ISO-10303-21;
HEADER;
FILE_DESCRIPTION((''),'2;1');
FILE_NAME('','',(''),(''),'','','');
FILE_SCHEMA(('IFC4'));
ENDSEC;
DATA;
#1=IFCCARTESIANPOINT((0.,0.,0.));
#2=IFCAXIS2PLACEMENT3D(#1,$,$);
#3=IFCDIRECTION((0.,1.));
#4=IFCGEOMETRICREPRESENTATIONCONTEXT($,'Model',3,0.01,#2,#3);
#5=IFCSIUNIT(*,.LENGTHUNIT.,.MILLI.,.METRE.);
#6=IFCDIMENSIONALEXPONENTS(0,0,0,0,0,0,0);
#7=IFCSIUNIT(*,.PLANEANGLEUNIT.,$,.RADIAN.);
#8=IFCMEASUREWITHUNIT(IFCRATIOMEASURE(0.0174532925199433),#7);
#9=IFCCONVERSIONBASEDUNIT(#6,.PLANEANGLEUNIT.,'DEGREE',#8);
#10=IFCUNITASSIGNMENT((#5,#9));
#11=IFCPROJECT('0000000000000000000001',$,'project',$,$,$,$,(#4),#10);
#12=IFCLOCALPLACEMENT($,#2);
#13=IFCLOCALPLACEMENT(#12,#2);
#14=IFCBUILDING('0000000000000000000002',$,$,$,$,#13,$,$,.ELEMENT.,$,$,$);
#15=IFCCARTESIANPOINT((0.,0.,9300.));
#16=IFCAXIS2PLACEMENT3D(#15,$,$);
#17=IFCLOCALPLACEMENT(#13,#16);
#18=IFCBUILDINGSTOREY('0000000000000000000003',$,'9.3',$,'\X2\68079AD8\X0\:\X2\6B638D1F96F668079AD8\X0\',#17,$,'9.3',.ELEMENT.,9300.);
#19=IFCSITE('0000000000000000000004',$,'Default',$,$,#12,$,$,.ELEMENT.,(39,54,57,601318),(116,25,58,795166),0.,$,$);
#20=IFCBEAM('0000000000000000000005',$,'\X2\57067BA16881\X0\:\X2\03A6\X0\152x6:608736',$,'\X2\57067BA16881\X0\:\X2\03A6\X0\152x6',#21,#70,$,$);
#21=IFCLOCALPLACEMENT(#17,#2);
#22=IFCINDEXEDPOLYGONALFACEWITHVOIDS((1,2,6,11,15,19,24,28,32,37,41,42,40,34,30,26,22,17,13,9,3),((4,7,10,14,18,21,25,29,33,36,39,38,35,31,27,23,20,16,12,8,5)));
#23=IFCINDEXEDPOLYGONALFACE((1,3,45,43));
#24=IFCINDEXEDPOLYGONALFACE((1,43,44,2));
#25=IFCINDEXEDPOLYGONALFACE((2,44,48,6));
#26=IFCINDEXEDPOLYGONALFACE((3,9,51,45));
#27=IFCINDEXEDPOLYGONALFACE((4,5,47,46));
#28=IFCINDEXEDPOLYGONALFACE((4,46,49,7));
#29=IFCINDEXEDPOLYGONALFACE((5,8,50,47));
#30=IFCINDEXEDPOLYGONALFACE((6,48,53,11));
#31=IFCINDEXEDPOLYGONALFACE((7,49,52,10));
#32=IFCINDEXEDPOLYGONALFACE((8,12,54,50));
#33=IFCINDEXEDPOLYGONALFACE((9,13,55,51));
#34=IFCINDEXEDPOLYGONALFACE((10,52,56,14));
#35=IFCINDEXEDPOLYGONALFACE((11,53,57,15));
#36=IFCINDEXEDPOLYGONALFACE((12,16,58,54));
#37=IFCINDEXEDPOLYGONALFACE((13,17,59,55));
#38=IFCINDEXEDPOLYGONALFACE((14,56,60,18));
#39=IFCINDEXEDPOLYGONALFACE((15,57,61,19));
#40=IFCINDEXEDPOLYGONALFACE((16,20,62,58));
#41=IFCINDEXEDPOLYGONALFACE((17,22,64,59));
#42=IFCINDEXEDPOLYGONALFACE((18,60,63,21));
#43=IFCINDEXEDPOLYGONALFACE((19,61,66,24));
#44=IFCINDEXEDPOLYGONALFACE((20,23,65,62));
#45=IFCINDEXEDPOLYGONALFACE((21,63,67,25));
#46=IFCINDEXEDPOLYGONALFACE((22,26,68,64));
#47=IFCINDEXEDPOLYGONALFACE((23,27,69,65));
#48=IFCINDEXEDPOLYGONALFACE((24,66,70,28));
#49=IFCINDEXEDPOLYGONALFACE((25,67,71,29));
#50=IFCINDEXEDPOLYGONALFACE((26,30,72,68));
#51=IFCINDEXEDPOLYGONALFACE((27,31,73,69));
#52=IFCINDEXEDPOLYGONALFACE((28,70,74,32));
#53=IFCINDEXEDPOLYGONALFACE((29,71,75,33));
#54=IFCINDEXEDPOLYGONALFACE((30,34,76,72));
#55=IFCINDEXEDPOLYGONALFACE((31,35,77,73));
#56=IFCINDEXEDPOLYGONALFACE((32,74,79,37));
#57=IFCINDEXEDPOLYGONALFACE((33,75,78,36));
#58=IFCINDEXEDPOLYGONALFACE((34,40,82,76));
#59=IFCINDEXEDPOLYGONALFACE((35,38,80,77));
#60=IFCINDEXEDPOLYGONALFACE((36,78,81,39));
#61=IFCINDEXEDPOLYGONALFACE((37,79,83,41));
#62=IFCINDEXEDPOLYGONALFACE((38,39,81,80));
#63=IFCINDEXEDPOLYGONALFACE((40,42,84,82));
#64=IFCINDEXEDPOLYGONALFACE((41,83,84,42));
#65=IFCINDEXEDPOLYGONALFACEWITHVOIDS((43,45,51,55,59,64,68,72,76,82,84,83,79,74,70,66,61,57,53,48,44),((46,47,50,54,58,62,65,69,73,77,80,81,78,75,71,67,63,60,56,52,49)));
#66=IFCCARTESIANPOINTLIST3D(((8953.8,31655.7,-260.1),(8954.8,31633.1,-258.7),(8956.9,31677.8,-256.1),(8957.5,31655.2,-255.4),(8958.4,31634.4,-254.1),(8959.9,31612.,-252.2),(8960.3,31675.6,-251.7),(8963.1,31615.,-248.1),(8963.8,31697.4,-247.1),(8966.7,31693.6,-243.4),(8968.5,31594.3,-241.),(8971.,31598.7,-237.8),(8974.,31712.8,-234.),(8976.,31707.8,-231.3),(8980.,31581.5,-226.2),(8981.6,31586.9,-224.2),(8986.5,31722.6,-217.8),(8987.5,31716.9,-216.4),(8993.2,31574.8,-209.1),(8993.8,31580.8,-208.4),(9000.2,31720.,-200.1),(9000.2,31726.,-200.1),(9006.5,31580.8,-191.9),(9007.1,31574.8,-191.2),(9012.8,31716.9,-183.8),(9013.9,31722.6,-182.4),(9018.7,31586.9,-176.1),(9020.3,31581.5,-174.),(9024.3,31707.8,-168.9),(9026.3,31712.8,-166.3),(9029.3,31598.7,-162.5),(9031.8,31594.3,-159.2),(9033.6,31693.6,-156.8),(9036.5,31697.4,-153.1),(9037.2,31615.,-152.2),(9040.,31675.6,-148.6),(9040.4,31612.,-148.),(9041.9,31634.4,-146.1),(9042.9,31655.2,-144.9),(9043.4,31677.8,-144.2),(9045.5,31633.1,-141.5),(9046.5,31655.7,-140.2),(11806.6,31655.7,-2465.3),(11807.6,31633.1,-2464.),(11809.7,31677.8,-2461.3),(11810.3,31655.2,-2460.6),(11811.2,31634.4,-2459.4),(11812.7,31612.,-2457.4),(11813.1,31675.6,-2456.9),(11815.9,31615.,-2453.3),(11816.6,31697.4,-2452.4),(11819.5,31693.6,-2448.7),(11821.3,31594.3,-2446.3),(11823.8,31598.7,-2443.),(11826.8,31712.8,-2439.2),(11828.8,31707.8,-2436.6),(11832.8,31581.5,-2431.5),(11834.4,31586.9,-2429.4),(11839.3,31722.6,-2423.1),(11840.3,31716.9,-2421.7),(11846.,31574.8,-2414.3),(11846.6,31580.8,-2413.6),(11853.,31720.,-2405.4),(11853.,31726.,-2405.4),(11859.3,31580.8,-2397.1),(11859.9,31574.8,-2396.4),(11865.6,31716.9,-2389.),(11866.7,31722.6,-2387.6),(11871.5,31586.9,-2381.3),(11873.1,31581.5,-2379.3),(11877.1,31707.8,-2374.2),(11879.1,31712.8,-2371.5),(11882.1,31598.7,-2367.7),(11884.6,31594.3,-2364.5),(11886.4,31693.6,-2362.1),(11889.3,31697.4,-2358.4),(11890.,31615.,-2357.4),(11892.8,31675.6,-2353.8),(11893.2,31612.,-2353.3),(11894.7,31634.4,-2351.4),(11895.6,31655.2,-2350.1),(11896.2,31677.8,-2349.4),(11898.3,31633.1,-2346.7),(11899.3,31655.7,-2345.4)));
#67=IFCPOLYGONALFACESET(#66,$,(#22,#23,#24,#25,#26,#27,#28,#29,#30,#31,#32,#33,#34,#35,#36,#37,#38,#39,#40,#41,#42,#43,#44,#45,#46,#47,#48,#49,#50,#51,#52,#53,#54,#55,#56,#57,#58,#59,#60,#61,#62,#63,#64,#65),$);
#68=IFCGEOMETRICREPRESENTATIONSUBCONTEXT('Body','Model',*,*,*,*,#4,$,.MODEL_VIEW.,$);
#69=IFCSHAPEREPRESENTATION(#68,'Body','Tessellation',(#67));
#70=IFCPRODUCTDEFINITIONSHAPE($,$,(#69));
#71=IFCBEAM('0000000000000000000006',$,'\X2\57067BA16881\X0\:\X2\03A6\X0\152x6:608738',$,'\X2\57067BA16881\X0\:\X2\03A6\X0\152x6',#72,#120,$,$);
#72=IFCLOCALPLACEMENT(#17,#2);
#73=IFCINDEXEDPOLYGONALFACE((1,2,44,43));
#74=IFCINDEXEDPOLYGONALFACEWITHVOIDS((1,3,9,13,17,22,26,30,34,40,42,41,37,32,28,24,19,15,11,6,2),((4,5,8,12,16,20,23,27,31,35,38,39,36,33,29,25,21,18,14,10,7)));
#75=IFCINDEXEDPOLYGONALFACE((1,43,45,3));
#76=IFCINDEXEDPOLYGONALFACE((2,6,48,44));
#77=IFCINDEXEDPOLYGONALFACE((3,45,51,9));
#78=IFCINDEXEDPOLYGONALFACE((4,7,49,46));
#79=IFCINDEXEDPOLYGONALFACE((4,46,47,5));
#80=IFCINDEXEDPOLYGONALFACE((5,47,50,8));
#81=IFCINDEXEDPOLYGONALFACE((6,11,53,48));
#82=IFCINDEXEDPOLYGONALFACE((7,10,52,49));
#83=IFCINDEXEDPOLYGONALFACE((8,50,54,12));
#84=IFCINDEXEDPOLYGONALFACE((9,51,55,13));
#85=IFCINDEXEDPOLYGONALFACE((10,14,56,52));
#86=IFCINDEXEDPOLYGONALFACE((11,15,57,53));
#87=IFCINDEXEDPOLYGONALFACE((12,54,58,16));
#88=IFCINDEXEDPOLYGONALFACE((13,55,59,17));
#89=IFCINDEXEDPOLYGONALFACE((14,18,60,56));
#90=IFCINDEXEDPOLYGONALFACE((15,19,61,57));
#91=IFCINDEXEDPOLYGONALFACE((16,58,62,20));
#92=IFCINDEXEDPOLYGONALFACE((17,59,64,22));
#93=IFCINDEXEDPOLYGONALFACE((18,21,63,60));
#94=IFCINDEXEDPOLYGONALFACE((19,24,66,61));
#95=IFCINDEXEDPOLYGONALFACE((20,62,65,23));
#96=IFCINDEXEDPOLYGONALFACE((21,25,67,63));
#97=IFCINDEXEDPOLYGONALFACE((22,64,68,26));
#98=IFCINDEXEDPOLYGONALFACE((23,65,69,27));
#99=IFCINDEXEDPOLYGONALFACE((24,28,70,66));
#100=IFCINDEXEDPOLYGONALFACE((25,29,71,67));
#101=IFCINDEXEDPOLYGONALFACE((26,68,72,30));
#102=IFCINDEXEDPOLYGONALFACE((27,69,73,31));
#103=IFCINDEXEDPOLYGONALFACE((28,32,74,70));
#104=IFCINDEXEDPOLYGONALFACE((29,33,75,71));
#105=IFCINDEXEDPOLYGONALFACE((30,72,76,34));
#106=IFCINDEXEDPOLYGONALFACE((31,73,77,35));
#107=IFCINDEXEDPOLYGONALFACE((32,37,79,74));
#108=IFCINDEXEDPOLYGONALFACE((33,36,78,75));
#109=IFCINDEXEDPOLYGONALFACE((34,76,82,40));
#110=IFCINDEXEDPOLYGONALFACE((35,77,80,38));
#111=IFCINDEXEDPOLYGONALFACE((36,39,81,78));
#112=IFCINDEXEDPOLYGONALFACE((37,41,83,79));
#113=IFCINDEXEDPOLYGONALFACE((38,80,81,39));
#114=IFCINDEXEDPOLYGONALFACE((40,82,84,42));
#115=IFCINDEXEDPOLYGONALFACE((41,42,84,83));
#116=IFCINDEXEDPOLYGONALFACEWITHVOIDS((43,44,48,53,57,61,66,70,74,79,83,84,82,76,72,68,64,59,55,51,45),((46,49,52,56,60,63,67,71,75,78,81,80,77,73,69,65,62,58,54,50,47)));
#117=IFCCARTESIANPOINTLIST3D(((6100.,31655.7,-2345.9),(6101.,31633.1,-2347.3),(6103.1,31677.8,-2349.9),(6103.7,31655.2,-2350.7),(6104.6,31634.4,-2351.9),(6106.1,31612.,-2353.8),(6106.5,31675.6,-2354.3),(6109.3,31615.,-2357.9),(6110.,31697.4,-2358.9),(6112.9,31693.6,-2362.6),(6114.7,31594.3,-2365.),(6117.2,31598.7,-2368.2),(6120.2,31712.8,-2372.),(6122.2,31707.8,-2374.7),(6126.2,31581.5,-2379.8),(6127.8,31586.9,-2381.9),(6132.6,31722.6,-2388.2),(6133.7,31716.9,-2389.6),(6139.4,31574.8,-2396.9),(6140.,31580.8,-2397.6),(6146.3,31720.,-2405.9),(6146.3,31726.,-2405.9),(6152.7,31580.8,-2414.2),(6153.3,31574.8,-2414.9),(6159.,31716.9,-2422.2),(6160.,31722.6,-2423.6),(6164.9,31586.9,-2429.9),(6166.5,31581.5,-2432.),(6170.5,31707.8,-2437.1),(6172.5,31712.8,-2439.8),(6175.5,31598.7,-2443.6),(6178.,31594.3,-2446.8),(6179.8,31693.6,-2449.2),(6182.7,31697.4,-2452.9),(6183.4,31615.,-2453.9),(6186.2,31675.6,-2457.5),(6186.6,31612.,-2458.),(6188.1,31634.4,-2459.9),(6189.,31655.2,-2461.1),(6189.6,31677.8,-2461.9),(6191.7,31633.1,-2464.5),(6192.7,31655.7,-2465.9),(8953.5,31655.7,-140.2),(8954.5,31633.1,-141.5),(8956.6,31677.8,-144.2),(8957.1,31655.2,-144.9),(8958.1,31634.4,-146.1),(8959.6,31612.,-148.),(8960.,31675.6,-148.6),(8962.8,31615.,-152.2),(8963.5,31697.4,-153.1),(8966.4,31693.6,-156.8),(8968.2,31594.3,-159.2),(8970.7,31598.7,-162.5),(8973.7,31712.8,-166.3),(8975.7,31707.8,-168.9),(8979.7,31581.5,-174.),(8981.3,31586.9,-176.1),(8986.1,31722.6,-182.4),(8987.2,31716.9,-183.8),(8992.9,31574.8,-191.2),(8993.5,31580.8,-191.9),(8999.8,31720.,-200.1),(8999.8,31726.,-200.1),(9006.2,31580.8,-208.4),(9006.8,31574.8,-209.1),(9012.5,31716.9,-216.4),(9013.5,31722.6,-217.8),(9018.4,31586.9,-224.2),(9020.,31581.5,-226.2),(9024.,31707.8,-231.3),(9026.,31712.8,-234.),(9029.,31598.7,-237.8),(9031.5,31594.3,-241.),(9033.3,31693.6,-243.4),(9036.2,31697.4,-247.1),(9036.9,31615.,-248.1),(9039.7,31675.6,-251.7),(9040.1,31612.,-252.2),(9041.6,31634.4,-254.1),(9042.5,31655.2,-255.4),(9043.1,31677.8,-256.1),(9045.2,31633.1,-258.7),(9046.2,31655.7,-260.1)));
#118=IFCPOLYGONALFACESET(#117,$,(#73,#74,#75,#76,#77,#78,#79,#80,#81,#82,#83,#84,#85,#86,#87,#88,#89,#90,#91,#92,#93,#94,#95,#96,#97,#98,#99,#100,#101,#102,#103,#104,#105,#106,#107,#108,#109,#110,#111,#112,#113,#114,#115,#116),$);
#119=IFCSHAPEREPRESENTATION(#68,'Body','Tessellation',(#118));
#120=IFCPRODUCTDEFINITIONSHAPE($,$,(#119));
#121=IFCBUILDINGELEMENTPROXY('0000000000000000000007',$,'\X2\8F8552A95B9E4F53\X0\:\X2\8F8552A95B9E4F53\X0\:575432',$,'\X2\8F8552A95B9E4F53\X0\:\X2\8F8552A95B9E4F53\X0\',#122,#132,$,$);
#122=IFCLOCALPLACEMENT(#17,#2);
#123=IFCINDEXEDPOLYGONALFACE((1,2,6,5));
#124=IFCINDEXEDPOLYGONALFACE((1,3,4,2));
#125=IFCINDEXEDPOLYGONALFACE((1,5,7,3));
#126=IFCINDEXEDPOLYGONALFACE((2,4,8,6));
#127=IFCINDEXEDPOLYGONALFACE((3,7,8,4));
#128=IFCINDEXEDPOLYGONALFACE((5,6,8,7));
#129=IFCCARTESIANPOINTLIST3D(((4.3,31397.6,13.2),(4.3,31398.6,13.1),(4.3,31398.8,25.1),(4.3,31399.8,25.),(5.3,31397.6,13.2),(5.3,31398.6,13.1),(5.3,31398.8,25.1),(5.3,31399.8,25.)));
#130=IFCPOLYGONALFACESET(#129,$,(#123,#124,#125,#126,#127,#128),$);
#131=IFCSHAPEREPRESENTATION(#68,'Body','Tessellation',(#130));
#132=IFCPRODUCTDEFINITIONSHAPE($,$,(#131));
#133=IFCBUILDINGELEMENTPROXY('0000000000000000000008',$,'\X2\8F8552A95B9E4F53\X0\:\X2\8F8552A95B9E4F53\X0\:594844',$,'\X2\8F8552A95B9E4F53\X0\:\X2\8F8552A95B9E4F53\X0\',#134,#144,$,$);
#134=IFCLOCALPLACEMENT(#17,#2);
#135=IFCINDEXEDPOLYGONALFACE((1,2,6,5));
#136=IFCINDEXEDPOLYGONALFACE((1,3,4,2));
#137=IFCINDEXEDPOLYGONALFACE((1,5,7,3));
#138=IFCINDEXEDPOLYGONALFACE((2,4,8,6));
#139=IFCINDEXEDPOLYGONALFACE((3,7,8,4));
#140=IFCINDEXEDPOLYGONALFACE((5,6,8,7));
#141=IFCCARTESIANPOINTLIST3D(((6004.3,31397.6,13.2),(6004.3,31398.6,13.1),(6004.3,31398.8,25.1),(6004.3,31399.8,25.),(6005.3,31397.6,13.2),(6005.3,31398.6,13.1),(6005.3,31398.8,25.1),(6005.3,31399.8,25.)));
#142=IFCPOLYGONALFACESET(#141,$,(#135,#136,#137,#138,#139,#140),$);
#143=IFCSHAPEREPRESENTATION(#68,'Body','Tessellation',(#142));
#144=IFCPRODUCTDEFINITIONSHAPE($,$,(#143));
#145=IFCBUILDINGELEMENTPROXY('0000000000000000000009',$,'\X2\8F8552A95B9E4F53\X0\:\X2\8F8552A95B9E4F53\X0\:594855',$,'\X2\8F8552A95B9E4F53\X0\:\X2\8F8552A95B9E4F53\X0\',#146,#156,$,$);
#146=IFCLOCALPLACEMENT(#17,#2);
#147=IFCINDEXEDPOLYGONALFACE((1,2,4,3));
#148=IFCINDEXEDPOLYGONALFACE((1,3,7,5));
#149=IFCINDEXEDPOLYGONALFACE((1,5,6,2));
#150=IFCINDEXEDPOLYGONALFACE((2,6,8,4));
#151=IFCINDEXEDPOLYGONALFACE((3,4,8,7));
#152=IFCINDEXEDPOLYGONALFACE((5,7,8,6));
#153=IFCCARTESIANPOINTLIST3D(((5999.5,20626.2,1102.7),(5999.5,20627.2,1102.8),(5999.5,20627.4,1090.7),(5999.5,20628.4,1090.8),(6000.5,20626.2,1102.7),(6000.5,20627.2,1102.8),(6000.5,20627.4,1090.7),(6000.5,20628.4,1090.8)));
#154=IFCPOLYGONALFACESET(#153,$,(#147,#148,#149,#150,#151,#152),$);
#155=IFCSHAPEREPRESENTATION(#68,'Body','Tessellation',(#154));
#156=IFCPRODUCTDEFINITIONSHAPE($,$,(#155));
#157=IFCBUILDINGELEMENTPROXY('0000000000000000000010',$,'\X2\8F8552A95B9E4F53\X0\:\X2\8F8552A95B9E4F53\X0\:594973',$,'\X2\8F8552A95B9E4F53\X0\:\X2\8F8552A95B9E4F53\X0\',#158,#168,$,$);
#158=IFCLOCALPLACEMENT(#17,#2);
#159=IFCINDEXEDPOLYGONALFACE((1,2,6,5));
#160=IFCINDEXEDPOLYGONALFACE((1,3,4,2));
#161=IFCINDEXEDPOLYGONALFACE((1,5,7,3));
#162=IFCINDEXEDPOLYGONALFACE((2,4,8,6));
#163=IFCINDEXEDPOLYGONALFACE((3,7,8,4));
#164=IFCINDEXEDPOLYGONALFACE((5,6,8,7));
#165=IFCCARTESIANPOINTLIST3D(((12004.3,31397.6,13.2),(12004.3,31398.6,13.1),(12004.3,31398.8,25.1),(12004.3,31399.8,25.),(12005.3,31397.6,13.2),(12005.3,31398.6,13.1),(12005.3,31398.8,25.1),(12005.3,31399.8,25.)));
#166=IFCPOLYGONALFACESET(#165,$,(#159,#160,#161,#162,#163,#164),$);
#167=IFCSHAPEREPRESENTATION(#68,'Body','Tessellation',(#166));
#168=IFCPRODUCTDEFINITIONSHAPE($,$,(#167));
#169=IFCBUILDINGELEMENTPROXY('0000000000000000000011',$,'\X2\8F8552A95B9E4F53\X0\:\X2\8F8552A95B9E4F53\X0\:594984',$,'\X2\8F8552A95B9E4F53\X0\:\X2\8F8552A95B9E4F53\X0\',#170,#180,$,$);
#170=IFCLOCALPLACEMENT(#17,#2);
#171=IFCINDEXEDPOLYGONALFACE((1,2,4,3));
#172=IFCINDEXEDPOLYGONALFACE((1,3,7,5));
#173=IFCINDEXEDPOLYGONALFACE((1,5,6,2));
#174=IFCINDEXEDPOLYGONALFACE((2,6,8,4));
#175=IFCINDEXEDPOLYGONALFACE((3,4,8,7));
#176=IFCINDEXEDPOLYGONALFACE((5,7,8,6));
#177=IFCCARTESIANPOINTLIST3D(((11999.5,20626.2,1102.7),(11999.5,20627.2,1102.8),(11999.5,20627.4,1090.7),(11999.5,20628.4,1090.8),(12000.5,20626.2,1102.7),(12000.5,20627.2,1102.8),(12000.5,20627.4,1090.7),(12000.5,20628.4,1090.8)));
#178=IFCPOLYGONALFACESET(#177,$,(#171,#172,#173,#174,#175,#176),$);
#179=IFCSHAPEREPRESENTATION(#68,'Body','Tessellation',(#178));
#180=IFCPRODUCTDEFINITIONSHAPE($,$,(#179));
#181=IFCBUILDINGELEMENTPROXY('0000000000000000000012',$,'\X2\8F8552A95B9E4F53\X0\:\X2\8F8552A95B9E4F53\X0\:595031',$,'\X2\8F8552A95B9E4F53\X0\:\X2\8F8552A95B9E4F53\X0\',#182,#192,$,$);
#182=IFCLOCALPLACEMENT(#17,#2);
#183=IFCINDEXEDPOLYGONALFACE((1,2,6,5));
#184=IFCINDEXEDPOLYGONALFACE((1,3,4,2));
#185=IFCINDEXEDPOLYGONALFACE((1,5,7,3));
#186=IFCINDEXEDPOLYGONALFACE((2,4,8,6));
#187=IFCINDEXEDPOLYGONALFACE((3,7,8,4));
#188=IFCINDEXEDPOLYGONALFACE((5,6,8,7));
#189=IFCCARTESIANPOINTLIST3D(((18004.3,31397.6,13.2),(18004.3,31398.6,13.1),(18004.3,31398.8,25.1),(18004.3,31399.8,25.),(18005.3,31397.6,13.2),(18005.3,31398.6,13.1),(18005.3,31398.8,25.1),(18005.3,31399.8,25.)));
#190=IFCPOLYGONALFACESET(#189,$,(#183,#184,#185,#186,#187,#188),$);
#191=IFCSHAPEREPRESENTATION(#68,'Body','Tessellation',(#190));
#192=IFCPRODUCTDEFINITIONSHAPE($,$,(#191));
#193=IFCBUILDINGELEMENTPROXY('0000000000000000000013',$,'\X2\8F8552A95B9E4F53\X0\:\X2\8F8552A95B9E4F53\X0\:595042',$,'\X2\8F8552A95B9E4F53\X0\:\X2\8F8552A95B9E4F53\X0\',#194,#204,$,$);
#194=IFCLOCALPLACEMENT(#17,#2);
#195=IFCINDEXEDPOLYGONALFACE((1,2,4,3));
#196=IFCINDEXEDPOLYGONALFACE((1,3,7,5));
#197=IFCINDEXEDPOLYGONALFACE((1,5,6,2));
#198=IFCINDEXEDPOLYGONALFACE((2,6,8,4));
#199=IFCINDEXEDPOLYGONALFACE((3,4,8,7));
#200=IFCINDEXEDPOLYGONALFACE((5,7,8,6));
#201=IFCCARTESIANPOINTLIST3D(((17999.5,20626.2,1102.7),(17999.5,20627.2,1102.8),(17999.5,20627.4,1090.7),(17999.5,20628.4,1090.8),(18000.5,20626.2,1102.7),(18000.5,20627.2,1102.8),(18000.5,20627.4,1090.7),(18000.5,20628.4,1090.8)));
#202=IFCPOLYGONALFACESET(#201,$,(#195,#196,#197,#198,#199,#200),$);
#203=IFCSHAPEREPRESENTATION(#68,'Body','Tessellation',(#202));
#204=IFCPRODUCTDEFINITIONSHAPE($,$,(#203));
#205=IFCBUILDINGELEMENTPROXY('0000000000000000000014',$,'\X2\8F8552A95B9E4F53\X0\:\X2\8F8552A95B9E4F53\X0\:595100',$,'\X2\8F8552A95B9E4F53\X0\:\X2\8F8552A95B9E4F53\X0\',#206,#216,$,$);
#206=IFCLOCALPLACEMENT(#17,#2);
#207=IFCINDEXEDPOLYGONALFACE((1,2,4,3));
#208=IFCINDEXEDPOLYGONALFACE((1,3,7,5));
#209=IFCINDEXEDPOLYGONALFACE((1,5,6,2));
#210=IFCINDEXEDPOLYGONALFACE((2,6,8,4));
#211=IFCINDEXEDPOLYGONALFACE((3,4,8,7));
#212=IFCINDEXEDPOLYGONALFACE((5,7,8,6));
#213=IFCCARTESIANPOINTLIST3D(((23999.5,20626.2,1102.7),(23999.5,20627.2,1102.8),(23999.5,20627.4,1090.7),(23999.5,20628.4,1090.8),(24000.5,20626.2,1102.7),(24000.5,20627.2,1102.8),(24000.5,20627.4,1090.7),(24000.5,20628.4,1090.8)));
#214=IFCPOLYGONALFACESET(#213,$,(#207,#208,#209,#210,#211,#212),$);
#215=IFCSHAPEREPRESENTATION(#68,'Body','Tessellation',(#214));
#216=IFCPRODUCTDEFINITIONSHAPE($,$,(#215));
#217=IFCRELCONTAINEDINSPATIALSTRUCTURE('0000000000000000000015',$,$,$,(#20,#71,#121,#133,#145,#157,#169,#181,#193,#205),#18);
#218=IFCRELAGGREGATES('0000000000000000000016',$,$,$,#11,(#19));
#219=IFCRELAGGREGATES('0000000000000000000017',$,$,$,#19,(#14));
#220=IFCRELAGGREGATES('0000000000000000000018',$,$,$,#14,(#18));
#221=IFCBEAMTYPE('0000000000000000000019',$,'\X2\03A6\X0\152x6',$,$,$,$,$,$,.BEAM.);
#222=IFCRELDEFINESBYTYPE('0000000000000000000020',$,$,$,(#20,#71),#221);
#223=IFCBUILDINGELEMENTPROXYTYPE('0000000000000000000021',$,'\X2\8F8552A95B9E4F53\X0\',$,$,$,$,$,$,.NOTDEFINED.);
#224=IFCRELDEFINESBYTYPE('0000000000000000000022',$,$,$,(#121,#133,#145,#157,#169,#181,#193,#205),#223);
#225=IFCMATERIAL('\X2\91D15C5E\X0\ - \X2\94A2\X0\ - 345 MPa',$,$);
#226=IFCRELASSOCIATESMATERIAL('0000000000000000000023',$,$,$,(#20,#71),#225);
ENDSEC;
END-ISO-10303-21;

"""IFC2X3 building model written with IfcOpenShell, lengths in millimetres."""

from ifc_helpers import new_model, entity, si_unit, converted_unit, direction, frame, origin, origin_2d_with_axis, place, context, subcontext, project, spatial, rectangle, hollow_circle, extrude, source, transform, mapped, material, type_object, type_shapes, element, save


model = new_model("IFC2X3")

# Units and contexts
model_context = context("Model", 3, precision=0.01, world=origin(), true_north=direction((0.0, 1.0)))
body_context = subcontext(model_context, "Body", "Model", "MODEL_VIEW")
ifc_project = project(units=[si_unit("LENGTHUNIT", "METRE", prefix="MILLI"), converted_unit("PLANEANGLEUNIT", "DEGREE", entity("IfcRatioMeasure", 0.0174532925199433), si_unit("PLANEANGLEUNIT", "RADIAN"), dimensions=[0, 0, 0, 0, 0, 0, 0])], contexts=[model_context])

# Site, building, storey
site_placement = place(None, origin())
site = spatial("IfcSite", under=ifc_project, at=site_placement, Name="Default", CompositionType="ELEMENT", RefLatitude=(39, 54, 57, 601318), RefLongitude=(116, 25, 58, 795166), RefElevation=0.0)
building_placement = place(site_placement, origin())
building = spatial("IfcBuilding", under=site, at=building_placement, CompositionType="ELEMENT")
storey_placement = place(building_placement, frame((0.0, 0.0, 9300.0)))
storey = spatial("IfcBuildingStorey", under=building, at=storey_placement, Name="9.3", ObjectType="标高:正负零标高", LongName="9.3", CompositionType="ELEMENT", Elevation=9300.0)

# Beams
ifc_material = material(Name="金属 - 钢 - 345 MPa")
beam_type_1 = type_object("IfcBeamType", Name="Φ152x6", PredefinedType="BEAM")
beam_1_placement = place(storey_placement, frame((6970.1, 31650.0, 1621.9), z_axis=(0.611588, 0.0, 0.791177), x_axis=(0.791177, 0.0, -0.611588)))
element("IfcBeam", 1, at=beam_1_placement, inside=storey, type_object=beam_type_1, material=ifc_material, Name="圆管梁:Φ152x6:608736", ObjectType="圆管梁:Φ152x6", context=body_context, shape_type="SweptSolid", body=[
    extrude(hollow_circle(Radius=76.0, WallThickness=6.0, at=origin_2d_with_axis()), frame((2720.4, 0.0, -200.0), z_axis=(1.0, 0.0, 0.0), x_axis=(0.0, 1.0, 0.0)), (0.0, 0.0, 1.0), 3605.8),
])
beam_2_placement = place(storey_placement, frame((11092.5, 31650.0, 1670.3), z_axis=(-0.611588, 0.0, 0.791177), x_axis=(-0.791177, 0.0, -0.611588)))
element("IfcBeam", 2, at=beam_2_placement, inside=storey, type_object=beam_type_1, material=ifc_material, Name="圆管梁:Φ152x6:608738", ObjectType="圆管梁:Φ152x6", context=body_context, shape_type="SweptSolid", body=[
    extrude(hollow_circle(Radius=76.0, WallThickness=6.0, at=origin_2d_with_axis()), frame((2799.6, 0.0, -200.0), z_axis=(1.0, 0.0, 0.0), x_axis=(0.0, -1.0, 0.0)), (0.0, 0.0, 1.0), 3606.6),
])

# Building element proxies
building_element_proxy_type = type_object("IfcBuildingElementProxyType", Name="辅助实体", PredefinedType="NOTDEFINED")
shared_shape_1 = source(origin(), body_context, "Body", "SweptSolid", [
    extrude(rectangle(XDim=1.0, YDim=1.0, at=origin_2d_with_axis()), frame((0.0, 0.0, -12.0), z_axis=(0.0, 0.0, 1.0), x_axis=(-1.0, 0.0, 0.0)), (0.0, 0.0, 1.0), 12.0),
])
type_shapes(building_element_proxy_type, [shared_shape_1])
for number, where, z_axis, x_axis, name in (
    (3, (4.8, 31398.1, 13.1), (-0.000073, -0.099548, -0.995033), (-0.000728, -0.995032, 0.099548), "辅助实体:辅助实体:575432"),
    (4, (6004.8, 31398.1, 13.1), (-0.000073, -0.099548, -0.995033), (-0.000728, -0.995032, 0.099548), "辅助实体:辅助实体:594844"),
    (5, (6000.0, 20627.9, 1090.8), (0.0, 0.099548, -0.995033), (0.0, -0.995033, -0.099548), "辅助实体:辅助实体:594855"),
    (6, (12004.8, 31398.1, 13.1), (-0.000073, -0.099548, -0.995033), (-0.000728, -0.995032, 0.099548), "辅助实体:辅助实体:594973"),
    (7, (12000.0, 20627.9, 1090.8), (0.0, 0.099548, -0.995033), (0.0, -0.995033, -0.099548), "辅助实体:辅助实体:594984"),
    (8, (18004.8, 31398.1, 13.1), (-0.000073, -0.099548, -0.995033), (-0.000728, -0.995032, 0.099548), "辅助实体:辅助实体:595031"),
    (9, (18000.0, 20627.9, 1090.8), (0.0, 0.099548, -0.995033), (0.0, -0.995033, -0.099548), "辅助实体:辅助实体:595042"),
    (10, (24000.0, 20627.9, 1090.8), (0.0, 0.099548, -0.995033), (0.0, -0.995033, -0.099548), "辅助实体:辅助实体:595100"),
):
    element("IfcBuildingElementProxy", number, at=place(storey_placement, frame(where, z_axis=z_axis, x_axis=x_axis)), inside=storey, type_object=building_element_proxy_type, Name=name, ObjectType="辅助实体:辅助实体", context=body_context, shape_type="MappedRepresentation", body=[
        mapped(shared_shape_1, transform((0.0, 0.0, 0.0), scale=1.0)),
    ])

save(model, "model.ifc")
